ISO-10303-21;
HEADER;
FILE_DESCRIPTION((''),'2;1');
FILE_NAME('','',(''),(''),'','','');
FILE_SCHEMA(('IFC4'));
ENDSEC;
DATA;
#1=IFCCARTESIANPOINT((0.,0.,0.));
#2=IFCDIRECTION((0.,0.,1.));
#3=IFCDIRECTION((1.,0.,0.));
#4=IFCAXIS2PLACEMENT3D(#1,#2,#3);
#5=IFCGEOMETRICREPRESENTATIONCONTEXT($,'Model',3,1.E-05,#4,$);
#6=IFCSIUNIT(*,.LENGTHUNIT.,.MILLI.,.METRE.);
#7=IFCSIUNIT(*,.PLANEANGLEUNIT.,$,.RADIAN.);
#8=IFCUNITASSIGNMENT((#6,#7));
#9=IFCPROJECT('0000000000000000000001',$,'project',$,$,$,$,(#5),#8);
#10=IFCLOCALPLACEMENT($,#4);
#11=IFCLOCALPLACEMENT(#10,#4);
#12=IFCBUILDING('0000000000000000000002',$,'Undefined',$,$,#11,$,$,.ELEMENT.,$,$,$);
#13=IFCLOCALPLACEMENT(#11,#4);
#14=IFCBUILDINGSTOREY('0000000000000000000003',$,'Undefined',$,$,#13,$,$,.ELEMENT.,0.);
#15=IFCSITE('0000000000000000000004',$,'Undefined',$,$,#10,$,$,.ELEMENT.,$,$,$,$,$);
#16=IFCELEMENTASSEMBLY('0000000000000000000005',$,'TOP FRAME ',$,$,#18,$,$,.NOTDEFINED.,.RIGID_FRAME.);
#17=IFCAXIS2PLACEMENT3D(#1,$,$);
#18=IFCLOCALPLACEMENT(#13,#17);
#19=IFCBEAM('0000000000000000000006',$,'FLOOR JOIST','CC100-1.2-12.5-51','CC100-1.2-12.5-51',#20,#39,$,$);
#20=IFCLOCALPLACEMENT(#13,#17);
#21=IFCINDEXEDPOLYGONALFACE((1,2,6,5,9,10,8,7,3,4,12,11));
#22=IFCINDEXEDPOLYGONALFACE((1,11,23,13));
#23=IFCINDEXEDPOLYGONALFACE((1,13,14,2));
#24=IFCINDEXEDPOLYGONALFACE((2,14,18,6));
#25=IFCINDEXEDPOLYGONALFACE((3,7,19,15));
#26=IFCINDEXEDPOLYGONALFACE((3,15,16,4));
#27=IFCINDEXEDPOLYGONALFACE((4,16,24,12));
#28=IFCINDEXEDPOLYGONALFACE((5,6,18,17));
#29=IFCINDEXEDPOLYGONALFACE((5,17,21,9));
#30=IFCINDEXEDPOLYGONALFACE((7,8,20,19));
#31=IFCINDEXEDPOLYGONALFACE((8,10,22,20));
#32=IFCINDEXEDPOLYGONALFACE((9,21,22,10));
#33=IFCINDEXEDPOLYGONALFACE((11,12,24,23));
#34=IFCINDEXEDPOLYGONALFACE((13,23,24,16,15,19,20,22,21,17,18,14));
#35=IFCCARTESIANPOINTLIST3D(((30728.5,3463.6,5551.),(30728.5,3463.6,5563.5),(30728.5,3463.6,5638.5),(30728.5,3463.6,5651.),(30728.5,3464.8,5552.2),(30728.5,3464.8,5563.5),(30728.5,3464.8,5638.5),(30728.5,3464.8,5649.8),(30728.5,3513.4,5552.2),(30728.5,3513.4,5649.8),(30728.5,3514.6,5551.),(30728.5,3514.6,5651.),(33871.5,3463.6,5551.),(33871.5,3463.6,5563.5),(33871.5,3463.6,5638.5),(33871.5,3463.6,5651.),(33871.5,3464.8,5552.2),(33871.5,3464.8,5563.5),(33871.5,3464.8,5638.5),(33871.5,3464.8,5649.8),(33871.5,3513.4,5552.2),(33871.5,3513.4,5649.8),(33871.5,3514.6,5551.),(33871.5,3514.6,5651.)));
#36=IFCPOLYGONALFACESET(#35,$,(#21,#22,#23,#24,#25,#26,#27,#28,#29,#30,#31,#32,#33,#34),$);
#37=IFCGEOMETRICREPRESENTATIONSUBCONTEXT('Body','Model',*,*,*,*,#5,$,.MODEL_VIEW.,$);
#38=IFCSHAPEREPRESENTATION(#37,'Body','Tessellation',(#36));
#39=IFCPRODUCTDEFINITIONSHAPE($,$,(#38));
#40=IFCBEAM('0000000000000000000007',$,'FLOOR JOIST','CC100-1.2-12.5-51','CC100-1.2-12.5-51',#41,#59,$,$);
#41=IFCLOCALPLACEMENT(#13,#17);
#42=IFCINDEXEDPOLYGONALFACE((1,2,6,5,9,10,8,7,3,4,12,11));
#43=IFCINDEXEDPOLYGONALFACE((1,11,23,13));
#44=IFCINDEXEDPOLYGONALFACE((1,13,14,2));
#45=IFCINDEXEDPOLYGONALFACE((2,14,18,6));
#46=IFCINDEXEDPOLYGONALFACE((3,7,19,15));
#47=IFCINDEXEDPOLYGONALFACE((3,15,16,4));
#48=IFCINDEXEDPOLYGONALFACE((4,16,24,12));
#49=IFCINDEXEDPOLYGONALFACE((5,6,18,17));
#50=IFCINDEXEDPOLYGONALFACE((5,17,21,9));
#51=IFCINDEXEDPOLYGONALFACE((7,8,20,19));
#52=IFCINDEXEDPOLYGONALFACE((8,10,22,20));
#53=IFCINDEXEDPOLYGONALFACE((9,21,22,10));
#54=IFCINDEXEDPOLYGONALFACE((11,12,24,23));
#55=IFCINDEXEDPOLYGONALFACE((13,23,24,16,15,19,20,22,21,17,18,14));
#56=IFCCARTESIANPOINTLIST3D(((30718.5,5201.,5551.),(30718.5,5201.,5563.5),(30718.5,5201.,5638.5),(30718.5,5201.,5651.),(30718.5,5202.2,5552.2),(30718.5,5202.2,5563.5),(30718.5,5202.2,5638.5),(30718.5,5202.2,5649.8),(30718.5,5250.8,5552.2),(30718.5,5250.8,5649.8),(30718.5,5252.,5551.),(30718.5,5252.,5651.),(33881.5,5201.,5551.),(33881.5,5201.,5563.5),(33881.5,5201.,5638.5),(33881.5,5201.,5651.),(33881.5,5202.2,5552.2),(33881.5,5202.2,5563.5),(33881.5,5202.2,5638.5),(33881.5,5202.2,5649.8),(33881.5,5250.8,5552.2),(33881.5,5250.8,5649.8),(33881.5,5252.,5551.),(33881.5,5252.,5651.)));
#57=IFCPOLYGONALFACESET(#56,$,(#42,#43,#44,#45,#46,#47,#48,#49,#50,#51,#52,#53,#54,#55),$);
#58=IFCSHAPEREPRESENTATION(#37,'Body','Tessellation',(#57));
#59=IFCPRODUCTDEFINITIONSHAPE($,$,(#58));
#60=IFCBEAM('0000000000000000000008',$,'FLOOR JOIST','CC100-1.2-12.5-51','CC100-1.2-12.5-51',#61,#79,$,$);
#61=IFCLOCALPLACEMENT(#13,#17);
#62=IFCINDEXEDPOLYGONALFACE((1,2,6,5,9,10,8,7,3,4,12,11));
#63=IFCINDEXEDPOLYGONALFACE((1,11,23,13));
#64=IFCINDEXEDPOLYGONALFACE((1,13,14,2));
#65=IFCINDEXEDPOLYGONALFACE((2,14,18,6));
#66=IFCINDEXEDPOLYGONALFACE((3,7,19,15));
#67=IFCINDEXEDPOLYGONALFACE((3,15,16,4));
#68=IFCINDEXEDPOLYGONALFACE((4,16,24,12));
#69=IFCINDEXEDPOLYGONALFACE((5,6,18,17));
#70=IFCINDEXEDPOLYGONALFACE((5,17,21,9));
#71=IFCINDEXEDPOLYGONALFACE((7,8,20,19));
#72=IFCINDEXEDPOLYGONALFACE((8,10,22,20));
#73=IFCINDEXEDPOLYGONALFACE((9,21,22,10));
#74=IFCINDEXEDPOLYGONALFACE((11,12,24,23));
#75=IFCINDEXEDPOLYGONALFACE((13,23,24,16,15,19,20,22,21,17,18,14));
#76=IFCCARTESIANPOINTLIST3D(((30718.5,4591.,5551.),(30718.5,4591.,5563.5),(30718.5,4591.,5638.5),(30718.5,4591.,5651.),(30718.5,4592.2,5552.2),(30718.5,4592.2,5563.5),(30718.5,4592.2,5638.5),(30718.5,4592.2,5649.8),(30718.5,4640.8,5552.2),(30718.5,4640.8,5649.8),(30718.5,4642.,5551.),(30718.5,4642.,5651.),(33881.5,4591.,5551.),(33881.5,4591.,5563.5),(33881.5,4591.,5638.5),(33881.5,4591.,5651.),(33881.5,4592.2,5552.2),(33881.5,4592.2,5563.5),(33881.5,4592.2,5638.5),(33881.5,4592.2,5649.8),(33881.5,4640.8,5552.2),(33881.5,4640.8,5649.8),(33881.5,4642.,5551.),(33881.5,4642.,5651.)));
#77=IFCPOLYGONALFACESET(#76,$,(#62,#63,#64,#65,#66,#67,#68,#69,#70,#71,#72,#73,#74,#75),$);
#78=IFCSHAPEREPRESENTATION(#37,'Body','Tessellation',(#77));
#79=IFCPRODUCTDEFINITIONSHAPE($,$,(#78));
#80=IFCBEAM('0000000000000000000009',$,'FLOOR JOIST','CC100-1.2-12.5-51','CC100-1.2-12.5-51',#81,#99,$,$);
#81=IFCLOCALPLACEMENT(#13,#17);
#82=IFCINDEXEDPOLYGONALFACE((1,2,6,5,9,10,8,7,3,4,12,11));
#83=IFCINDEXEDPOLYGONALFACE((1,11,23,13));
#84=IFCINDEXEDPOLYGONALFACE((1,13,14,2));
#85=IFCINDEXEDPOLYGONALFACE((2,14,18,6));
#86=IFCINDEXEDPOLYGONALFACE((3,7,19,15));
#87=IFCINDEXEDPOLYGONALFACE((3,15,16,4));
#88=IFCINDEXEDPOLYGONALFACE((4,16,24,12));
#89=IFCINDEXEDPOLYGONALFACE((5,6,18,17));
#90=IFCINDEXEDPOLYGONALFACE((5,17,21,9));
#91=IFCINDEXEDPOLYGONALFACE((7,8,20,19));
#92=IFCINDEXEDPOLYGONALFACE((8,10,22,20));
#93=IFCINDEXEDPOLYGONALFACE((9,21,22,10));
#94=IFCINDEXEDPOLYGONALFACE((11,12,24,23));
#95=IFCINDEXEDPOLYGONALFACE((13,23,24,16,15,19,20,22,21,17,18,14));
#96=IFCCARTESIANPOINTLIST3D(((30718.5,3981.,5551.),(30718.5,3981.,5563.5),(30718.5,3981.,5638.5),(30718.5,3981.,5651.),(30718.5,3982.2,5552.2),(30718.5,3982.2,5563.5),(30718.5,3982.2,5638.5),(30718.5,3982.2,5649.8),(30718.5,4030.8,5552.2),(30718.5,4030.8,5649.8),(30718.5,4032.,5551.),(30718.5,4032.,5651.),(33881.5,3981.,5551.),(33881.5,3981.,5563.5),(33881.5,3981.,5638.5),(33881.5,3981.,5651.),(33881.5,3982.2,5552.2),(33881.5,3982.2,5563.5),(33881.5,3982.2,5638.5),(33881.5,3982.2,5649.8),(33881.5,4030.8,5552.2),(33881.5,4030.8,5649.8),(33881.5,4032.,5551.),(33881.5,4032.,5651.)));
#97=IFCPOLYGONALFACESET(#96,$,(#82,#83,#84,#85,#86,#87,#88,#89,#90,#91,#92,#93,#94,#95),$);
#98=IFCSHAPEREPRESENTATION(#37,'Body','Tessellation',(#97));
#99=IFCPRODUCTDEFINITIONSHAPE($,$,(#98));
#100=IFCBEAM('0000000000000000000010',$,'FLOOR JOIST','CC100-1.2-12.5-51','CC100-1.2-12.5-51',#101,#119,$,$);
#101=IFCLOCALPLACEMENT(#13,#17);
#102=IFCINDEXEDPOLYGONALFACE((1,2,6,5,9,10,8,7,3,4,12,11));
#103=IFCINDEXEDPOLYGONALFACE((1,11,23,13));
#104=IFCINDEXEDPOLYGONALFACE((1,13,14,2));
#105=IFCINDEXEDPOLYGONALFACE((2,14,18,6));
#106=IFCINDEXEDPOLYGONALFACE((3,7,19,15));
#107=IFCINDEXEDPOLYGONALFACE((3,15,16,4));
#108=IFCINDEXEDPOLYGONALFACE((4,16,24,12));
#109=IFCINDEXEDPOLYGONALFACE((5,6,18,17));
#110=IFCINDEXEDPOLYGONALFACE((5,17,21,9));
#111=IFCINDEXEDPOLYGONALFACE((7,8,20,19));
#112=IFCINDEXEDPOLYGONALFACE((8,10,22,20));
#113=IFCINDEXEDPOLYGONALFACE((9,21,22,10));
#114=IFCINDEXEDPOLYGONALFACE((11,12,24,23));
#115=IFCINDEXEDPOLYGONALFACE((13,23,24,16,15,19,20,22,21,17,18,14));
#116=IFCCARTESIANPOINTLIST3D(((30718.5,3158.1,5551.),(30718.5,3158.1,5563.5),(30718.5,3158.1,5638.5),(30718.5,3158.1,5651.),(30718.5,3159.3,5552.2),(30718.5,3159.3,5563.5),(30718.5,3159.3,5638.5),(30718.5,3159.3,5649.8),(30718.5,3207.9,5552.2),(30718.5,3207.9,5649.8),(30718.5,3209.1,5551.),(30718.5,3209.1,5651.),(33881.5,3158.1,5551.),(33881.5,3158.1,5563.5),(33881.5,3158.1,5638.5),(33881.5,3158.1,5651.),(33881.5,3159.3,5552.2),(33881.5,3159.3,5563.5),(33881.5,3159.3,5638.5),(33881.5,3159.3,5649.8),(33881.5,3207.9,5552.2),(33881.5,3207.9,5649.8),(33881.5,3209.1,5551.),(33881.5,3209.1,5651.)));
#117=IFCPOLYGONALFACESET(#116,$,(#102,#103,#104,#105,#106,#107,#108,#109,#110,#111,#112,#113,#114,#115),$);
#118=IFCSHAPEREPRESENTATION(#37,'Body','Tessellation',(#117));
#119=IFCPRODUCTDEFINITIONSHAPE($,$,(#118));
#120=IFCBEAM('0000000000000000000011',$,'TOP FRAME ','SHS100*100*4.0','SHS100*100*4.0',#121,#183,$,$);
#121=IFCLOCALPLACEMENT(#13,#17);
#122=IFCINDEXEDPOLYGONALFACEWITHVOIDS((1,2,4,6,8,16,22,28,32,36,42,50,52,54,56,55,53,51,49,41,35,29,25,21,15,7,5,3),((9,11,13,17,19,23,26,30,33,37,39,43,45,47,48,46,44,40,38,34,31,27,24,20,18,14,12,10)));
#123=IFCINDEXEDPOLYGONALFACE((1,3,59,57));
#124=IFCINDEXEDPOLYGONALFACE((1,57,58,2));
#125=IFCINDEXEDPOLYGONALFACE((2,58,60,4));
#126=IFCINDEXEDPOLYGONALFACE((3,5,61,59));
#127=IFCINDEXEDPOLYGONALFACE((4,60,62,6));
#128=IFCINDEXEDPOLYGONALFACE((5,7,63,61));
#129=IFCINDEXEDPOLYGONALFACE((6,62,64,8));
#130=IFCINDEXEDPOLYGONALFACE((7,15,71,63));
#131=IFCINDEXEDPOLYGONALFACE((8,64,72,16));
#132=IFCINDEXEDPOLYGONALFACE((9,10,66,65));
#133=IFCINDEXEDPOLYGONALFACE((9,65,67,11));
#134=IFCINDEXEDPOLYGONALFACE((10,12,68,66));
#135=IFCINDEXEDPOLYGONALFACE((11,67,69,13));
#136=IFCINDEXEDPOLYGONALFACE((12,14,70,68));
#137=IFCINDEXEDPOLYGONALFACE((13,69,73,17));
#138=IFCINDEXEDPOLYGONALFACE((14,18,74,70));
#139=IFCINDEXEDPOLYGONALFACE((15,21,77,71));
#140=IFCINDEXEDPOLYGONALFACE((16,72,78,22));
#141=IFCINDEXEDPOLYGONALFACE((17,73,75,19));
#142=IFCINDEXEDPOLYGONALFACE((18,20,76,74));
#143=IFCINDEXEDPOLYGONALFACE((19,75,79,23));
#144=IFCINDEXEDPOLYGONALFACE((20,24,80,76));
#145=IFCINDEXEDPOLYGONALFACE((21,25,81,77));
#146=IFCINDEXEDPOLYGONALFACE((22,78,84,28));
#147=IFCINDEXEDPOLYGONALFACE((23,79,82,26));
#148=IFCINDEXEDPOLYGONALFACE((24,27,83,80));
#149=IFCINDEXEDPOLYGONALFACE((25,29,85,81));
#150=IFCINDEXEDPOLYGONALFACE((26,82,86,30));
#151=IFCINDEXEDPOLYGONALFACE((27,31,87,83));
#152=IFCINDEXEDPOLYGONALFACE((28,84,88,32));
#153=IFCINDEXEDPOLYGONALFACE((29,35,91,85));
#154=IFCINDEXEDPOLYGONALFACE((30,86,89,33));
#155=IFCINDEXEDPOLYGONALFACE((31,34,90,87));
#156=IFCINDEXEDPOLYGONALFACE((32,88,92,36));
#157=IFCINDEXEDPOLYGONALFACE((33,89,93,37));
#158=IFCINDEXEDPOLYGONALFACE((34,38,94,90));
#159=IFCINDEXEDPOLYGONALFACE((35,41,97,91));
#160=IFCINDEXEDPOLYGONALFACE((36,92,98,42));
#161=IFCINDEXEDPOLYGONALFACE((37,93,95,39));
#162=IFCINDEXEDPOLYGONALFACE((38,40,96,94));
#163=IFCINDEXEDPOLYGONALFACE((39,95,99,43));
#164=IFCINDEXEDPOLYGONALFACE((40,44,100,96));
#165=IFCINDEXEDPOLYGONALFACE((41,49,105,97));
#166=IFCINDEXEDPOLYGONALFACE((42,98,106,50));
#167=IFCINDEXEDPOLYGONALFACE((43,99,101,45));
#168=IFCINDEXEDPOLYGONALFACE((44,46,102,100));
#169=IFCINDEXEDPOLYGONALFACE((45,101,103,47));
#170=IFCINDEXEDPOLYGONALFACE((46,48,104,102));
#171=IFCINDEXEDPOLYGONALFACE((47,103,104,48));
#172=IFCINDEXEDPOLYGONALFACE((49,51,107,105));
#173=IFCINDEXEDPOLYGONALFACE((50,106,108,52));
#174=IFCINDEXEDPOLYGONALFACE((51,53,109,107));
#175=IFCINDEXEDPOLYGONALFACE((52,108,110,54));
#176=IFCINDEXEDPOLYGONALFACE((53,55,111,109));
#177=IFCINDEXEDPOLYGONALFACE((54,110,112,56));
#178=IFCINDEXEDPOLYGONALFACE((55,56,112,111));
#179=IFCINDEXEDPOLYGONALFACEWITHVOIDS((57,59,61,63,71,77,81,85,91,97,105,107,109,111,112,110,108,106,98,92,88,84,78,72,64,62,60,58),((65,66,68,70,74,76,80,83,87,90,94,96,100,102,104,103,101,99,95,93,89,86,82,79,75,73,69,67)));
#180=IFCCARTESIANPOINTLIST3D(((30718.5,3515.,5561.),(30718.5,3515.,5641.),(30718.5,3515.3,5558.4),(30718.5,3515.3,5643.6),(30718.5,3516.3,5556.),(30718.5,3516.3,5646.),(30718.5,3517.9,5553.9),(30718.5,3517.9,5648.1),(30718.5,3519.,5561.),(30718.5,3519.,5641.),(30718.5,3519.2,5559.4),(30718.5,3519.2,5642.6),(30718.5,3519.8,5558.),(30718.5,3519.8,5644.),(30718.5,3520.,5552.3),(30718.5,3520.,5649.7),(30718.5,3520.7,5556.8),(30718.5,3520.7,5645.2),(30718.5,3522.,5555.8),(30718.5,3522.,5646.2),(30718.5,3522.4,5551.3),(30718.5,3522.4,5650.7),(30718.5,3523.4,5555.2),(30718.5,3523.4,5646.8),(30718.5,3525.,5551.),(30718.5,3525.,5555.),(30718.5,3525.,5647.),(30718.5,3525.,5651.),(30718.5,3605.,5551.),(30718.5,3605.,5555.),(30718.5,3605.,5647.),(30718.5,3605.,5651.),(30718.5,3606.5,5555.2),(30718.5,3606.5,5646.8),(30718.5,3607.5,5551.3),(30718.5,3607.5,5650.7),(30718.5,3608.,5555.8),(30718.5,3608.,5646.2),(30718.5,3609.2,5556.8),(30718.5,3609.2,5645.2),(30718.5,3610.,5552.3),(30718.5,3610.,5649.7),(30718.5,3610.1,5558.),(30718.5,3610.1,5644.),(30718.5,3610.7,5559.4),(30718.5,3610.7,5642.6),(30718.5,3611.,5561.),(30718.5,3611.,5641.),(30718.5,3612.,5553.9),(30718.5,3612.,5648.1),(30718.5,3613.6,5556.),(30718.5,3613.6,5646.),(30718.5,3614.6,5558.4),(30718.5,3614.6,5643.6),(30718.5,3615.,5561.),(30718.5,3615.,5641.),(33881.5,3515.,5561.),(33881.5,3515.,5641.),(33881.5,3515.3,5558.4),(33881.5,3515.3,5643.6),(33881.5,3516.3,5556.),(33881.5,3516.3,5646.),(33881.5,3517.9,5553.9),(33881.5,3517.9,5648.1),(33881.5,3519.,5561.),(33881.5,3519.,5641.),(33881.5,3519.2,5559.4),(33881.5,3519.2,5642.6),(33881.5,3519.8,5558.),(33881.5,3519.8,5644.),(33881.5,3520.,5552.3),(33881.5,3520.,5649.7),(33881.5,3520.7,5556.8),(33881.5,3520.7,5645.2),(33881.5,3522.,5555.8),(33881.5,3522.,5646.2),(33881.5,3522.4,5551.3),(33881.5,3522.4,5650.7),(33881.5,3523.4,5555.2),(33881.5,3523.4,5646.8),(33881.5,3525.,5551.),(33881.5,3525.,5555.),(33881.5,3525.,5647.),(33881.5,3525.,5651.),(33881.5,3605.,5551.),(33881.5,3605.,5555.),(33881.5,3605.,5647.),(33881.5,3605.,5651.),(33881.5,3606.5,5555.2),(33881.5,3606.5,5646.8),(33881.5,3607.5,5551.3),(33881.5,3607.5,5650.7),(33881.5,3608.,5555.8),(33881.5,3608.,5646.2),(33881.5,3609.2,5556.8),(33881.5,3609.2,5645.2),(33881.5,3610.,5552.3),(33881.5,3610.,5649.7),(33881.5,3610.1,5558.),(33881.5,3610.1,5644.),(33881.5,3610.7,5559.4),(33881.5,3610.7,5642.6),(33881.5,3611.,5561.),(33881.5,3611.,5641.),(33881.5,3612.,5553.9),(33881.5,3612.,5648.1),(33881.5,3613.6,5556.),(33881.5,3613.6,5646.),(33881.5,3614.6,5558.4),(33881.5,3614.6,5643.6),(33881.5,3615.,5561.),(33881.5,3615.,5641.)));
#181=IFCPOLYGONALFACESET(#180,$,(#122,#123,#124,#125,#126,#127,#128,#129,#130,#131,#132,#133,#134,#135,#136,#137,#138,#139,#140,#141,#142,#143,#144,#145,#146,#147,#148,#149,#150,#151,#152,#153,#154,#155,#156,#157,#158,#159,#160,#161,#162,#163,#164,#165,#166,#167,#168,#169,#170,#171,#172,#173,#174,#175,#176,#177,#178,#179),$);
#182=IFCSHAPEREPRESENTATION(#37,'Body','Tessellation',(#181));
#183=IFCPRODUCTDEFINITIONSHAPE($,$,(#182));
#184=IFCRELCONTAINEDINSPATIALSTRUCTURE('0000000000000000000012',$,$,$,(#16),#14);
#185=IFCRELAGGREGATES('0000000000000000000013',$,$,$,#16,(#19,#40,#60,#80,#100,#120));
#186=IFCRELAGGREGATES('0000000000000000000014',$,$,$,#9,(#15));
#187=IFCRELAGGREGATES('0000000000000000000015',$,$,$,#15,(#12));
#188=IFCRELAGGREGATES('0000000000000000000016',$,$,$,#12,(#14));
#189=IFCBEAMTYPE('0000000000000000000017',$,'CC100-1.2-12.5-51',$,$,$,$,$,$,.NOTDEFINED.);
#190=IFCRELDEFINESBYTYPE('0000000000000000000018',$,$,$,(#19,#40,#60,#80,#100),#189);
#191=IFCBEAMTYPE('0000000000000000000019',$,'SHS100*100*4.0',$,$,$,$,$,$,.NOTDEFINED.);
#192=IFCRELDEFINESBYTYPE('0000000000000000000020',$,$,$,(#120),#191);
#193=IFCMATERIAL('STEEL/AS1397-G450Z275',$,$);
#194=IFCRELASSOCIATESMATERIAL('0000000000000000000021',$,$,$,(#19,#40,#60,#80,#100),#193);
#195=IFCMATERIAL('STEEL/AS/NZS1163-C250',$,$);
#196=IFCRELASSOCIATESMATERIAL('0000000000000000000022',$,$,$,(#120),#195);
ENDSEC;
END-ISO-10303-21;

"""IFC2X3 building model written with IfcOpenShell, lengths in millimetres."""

from ifc_helpers import new_model, si_unit, frame, origin_with_axes, origin_2d_with_axis, place, context, subcontext, project, spatial, hollow_rectangle, c_section, extrude, material, type_object, element, aggregate, save


model = new_model("IFC2X3")

# Units and contexts
model_context = context("Model", 3, precision=1e-05, world=origin_with_axes())
body_context = subcontext(model_context, "Body", "Model", "MODEL_VIEW")
ifc_project = project(units=[si_unit("LENGTHUNIT", "METRE", prefix="MILLI"), si_unit("PLANEANGLEUNIT", "RADIAN")], contexts=[model_context])

# Site, building, storey
site_placement = place(None, origin_with_axes())
site = spatial("IfcSite", under=ifc_project, at=site_placement, Name="Undefined", CompositionType="ELEMENT")
building_placement = place(site_placement, origin_with_axes())
building = spatial("IfcBuilding", under=site, at=building_placement, Name="Undefined", CompositionType="ELEMENT")
storey_placement = place(building_placement, origin_with_axes())
storey = spatial("IfcBuildingStorey", under=building, at=storey_placement, Name="Undefined", CompositionType="ELEMENT", Elevation=0.0)

# Element assembly, beams
ifc_material_1 = material(Name="STEEL/AS/NZS1163-C250")
ifc_material_2 = material(Name="STEEL/AS1397-G450Z275")
beam_type_1 = type_object("IfcBeamType", Name="CC100-1.2-12.5-51", PredefinedType="NOTDEFINED")
assembly_1_placement = place(storey_placement, origin_with_axes())
assembly_1 = element("IfcElementAssembly", 1, at=assembly_1_placement, inside=storey, Name="TOP FRAME ", AssemblyPlace="NOTDEFINED", PredefinedType="RIGID_FRAME")
beam_1_placement = place(assembly_1_placement, frame((30728.5, 3489.1, 5601.0), z_axis=(0.0, 0.0, 1.0), x_axis=(1.0, 0.0, 0.0)))
beam_1 = element("IfcBeam", 2, at=beam_1_placement, type_object=beam_type_1, material=ifc_material_2, Name="FLOOR JOIST", Description="CC100-1.2-12.5-51", ObjectType="CC100-1.2-12.5-51", context=body_context, shape_type="SweptSolid", body=[
    extrude(c_section(Depth=100.0, Width=51.0, WallThickness=1.2, Girth=12.5, at=origin_2d_with_axis()), frame((3143.0, 0.0, 0.0), z_axis=(-1.0, 0.0, 0.0), x_axis=(0.0, -1.0, 0.0)), (0.0, 0.0, 1.0), 3143.0),
])
beam_2_placement = place(assembly_1_placement, frame((30718.5, 5226.5, 5601.0), z_axis=(0.0, 0.0, 1.0), x_axis=(1.0, 0.0, 0.0)))
beam_2 = element("IfcBeam", 3, at=beam_2_placement, type_object=beam_type_1, material=ifc_material_2, Name="FLOOR JOIST", Description="CC100-1.2-12.5-51", ObjectType="CC100-1.2-12.5-51", context=body_context, shape_type="SweptSolid", body=[
    extrude(c_section(Depth=100.0, Width=51.0, WallThickness=1.2, Girth=12.5, at=origin_2d_with_axis()), frame((3163.0, 0.0, 0.0), z_axis=(-1.0, 0.0, 0.0), x_axis=(0.0, -1.0, 0.0)), (0.0, 0.0, 1.0), 3163.0),
])
beam_3_placement = place(assembly_1_placement, frame((30718.5, 4616.5, 5601.0), z_axis=(0.0, 0.0, 1.0), x_axis=(1.0, 0.0, 0.0)))
beam_3 = element("IfcBeam", 4, at=beam_3_placement, type_object=beam_type_1, material=ifc_material_2, Name="FLOOR JOIST", Description="CC100-1.2-12.5-51", ObjectType="CC100-1.2-12.5-51", context=body_context, shape_type="SweptSolid", body=[
    extrude(c_section(Depth=100.0, Width=51.0, WallThickness=1.2, Girth=12.5, at=origin_2d_with_axis()), frame((3163.0, 0.0, 0.0), z_axis=(-1.0, 0.0, 0.0), x_axis=(0.0, -1.0, 0.0)), (0.0, 0.0, 1.0), 3163.0),
])
beam_4_placement = place(assembly_1_placement, frame((30718.5, 4006.5, 5601.0), z_axis=(0.0, 0.0, 1.0), x_axis=(1.0, 0.0, 0.0)))
beam_4 = element("IfcBeam", 5, at=beam_4_placement, type_object=beam_type_1, material=ifc_material_2, Name="FLOOR JOIST", Description="CC100-1.2-12.5-51", ObjectType="CC100-1.2-12.5-51", context=body_context, shape_type="SweptSolid", body=[
    extrude(c_section(Depth=100.0, Width=51.0, WallThickness=1.2, Girth=12.5, at=origin_2d_with_axis()), frame((3163.0, 0.0, 0.0), z_axis=(-1.0, 0.0, 0.0), x_axis=(0.0, -1.0, 0.0)), (0.0, 0.0, 1.0), 3163.0),
])
beam_5_placement = place(assembly_1_placement, frame((30718.5, 3183.6, 5601.0), z_axis=(0.0, 0.0, 1.0), x_axis=(1.0, 0.0, 0.0)))
beam_5 = element("IfcBeam", 6, at=beam_5_placement, type_object=beam_type_1, material=ifc_material_2, Name="FLOOR JOIST", Description="CC100-1.2-12.5-51", ObjectType="CC100-1.2-12.5-51", context=body_context, shape_type="SweptSolid", body=[
    extrude(c_section(Depth=100.0, Width=51.0, WallThickness=1.2, Girth=12.5, at=origin_2d_with_axis()), frame((3163.0, 0.0, 0.0), z_axis=(-1.0, 0.0, 0.0), x_axis=(0.0, -1.0, 0.0)), (0.0, 0.0, 1.0), 3163.0),
])
beam_type_2 = type_object("IfcBeamType", Name="SHS100*100*4.0", PredefinedType="NOTDEFINED")
beam_6_placement = place(assembly_1_placement, frame((33881.5, 3564.9, 5601.0), z_axis=(0.0, 0.0, 1.0), x_axis=(-1.0, 0.0, 0.0)))
beam_6 = element("IfcBeam", 7, at=beam_6_placement, type_object=beam_type_2, material=ifc_material_1, Name="TOP FRAME ", Description="SHS100*100*4.0", ObjectType="SHS100*100*4.0", context=body_context, shape_type="SweptSolid", body=[
    extrude(hollow_rectangle(XDim=100.0, YDim=100.0, WallThickness=4.0, InnerFilletRadius=6.0, OuterFilletRadius=10.0, at=origin_2d_with_axis()), frame((3163.0, 0.0, 0.0), z_axis=(-1.0, 0.0, 0.0), x_axis=(0.0, -1.0, 0.0)), (0.0, 0.0, 1.0), 3163.0),
])
aggregate(assembly_1, [beam_1, beam_2, beam_3, beam_4, beam_5, beam_6])

save(model, "model.ifc")
